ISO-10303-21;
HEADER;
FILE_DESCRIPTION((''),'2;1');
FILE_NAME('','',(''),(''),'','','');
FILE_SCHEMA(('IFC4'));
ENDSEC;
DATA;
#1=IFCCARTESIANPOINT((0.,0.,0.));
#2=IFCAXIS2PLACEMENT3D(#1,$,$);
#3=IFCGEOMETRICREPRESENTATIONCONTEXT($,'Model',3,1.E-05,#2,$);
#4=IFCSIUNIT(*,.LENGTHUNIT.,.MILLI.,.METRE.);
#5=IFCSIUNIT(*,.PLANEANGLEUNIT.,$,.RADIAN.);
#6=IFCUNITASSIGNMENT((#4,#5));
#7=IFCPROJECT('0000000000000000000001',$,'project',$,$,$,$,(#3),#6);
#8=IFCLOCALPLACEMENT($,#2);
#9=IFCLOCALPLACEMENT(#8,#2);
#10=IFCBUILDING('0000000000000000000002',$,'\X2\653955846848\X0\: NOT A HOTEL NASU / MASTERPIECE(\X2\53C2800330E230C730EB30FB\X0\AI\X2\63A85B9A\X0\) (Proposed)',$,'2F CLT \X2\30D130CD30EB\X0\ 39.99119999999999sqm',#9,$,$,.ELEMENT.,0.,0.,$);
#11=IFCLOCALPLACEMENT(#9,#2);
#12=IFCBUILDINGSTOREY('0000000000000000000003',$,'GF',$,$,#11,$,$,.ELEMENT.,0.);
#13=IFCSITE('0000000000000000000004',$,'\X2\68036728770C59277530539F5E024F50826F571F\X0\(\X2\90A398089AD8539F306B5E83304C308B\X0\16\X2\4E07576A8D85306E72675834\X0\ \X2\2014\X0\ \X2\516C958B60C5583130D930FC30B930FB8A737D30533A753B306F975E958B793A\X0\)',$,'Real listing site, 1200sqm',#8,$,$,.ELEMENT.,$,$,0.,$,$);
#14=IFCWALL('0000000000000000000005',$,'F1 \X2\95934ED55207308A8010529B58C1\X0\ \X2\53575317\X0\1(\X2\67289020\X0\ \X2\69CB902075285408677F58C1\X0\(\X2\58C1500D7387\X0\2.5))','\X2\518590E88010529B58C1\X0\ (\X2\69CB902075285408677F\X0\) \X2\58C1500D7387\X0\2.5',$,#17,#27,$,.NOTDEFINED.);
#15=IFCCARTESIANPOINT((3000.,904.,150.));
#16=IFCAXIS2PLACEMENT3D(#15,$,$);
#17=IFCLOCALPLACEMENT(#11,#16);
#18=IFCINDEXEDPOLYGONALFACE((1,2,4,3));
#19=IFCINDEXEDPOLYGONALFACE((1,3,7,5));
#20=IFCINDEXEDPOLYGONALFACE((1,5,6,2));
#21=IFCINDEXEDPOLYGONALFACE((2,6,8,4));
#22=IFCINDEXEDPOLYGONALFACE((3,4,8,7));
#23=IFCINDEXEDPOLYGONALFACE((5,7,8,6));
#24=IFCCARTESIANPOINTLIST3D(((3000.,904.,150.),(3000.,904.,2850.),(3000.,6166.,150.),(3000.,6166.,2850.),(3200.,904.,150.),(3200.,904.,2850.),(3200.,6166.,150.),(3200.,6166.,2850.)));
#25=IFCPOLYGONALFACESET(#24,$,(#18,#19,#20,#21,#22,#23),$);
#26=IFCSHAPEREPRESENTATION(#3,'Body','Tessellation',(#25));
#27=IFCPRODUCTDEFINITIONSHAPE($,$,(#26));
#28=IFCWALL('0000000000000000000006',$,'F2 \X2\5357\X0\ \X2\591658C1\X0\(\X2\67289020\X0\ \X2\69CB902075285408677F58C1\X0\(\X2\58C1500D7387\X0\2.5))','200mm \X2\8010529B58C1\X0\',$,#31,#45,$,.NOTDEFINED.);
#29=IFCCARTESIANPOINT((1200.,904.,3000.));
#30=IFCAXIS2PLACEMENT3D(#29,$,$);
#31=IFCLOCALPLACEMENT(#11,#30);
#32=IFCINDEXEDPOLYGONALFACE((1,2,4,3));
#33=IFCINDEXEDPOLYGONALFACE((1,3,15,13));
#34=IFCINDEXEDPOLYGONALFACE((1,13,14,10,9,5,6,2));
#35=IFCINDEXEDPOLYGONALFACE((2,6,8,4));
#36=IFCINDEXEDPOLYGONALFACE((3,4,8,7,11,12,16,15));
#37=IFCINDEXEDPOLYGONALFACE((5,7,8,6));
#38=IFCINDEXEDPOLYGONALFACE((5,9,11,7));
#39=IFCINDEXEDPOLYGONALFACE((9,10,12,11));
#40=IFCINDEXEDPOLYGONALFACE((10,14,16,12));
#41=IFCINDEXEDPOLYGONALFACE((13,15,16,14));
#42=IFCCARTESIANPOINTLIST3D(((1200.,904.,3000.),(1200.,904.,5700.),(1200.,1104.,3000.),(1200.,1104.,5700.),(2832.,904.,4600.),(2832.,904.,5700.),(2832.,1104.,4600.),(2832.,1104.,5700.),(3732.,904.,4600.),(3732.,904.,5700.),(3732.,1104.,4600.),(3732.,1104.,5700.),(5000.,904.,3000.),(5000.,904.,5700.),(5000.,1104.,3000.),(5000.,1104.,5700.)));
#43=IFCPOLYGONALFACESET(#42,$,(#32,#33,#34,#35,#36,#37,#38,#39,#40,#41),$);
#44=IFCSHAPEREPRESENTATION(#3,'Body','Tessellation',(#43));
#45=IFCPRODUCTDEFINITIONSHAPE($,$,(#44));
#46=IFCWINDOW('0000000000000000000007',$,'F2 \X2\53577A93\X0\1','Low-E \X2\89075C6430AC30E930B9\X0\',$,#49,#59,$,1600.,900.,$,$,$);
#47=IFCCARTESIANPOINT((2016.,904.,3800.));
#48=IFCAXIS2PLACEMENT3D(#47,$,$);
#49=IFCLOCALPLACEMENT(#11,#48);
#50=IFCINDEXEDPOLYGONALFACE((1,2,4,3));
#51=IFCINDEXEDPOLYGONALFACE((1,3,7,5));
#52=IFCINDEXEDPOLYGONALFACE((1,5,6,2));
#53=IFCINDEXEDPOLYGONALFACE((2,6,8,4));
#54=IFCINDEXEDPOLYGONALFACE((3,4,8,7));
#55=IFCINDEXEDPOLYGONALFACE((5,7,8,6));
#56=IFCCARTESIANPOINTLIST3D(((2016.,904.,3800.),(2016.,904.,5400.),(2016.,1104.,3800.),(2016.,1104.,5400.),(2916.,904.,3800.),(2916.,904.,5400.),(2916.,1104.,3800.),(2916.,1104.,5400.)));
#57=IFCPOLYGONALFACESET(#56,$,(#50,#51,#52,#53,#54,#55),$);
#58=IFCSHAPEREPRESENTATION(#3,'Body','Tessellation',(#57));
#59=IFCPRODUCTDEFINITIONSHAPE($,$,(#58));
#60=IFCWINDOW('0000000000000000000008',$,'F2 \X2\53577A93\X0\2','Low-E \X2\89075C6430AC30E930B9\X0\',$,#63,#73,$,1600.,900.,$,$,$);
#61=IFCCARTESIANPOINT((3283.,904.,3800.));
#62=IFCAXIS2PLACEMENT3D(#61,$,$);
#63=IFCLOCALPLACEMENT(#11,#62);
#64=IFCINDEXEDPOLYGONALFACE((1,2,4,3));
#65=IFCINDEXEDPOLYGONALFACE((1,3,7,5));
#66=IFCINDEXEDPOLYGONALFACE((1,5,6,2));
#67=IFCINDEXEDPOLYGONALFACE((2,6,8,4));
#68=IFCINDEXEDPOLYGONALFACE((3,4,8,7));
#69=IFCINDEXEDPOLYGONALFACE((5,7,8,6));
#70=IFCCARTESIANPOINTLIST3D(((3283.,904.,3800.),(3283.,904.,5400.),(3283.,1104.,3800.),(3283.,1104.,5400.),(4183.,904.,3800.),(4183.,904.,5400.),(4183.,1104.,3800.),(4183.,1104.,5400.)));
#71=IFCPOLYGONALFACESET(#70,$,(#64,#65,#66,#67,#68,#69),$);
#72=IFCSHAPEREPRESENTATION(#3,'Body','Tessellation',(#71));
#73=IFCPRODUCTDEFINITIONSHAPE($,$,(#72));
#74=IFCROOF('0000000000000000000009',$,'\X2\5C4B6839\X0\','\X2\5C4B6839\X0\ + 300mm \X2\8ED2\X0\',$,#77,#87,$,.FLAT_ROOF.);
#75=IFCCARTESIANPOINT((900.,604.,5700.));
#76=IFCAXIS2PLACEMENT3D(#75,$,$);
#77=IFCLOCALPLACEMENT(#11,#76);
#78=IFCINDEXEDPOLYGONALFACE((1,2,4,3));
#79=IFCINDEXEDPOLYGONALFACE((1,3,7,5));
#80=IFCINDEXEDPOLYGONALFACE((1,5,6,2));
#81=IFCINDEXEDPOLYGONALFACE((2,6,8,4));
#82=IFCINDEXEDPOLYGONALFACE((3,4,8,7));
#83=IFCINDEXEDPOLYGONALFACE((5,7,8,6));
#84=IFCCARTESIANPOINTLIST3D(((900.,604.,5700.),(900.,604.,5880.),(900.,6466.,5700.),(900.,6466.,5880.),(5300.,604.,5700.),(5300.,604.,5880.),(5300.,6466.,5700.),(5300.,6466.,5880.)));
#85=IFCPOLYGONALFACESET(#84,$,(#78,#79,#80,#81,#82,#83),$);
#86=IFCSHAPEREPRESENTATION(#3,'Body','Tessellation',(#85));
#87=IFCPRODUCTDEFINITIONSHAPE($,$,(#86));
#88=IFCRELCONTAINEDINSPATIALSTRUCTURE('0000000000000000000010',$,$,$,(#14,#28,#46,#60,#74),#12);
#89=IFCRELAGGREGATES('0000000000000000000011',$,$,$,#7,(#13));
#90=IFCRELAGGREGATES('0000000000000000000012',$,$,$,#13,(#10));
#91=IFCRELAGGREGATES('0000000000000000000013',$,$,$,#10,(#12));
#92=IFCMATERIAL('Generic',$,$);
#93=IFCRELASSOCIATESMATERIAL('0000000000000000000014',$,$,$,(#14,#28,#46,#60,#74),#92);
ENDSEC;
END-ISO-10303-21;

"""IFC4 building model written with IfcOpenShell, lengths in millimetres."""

from ifc_helpers import new_model, si_unit, frame, frame_2d, origin, place, context, project, spatial, rectangle, extrude, material, element, fill, save


model = new_model("IFC4")

# Units and contexts
model_context = context("Model", 3, precision=1e-05, world=origin())
ifc_project = project(units=[si_unit("LENGTHUNIT", "METRE", prefix="MILLI"), si_unit("PLANEANGLEUNIT", "RADIAN")], contexts=[model_context])

# Site, building, storey
site_placement = place(None, origin())
site = spatial("IfcSite", under=ifc_project, at=site_placement, Name="栃木県大田原市佐良土(那須高原に広がる16万坪超の牧場 — 公開情報ベース・詳細区画は非開示)", ObjectType="Real listing site, 1200sqm", CompositionType="ELEMENT", RefElevation=0.0)
building_placement = place(site_placement, origin())
building = spatial("IfcBuilding", under=site, at=building_placement, Name="改善案: NOT A HOTEL NASU / MASTERPIECE(参考モデル・AI推定) (Proposed)", ObjectType="2F CLT パネル 39.99119999999999sqm", CompositionType="ELEMENT", ElevationOfRefHeight=0.0, ElevationOfTerrain=0.0)
storey_placement = place(building_placement, origin())
storey = spatial("IfcBuildingStorey", under=building, at=storey_placement, Name="GF", CompositionType="ELEMENT", Elevation=0.0)

# Shared definitions
ifc_material_1 = material(Name="Generic")

# Wall
wall_1_placement = place(storey_placement, frame((3000.0, 904.0, 150.0)))
element("IfcWall", 1, at=wall_1_placement, inside=storey, material=ifc_material_1, Name="F1 間仕切り耐力壁 南北1(木造 構造用合板壁(壁倍率2.5))", Description="内部耐力壁 (構造用合板) 壁倍率2.5", PredefinedType="NOTDEFINED", context=model_context, shape_type="SweptSolid", body=[
    extrude(rectangle(XDim=200.0, YDim=5262.0, at=frame_2d((100.0, 2631.0))), frame((3000.0, 904.0, 150.0)), (0.0, 0.0, 1.0), 2700.0),
])

# Wall, openings, windows
wall_2_placement = place(storey_placement, frame((1200.0, 904.0, 3000.0)))
wall_2 = element("IfcWall", 2, at=wall_2_placement, inside=storey, material=ifc_material_1, Name="F2 南 外壁(木造 構造用合板壁(壁倍率2.5))", Description="200mm 耐力壁", PredefinedType="NOTDEFINED", context=model_context, shape_type="SweptSolid", body=[
    extrude(rectangle(XDim=3800.0, YDim=200.0, at=frame_2d((1900.0, 100.0))), frame((1200.0, 904.0, 3000.0)), (0.0, 0.0, 1.0), 2700.0),
])
opening_1_placement = place(storey_placement, frame((2016.0, 904.0, 3800.0)))
opening_1 = element("IfcOpeningElement", 3, at=opening_1_placement, cuts=wall_2, PredefinedType="NOTDEFINED", context=model_context, shape_type="SweptSolid", body=[
    extrude(rectangle(XDim=900.0, YDim=200.0, at=frame_2d((450.0, 100.0))), frame((2016.0, 904.0, 3800.0)), (0.0, 0.0, 1.0), 1600.0),
])
opening_2_placement = place(storey_placement, frame((3283.0, 904.0, 3800.0)))
opening_2 = element("IfcOpeningElement", 4, at=opening_2_placement, cuts=wall_2, PredefinedType="NOTDEFINED", context=model_context, shape_type="SweptSolid", body=[
    extrude(rectangle(XDim=900.0, YDim=200.0, at=frame_2d((450.0, 100.0))), frame((3283.0, 904.0, 3800.0)), (0.0, 0.0, 1.0), 1600.0),
])
window_1_placement = place(storey_placement, frame((2016.0, 904.0, 3800.0)))
window_1 = element("IfcWindow", 5, at=window_1_placement, inside=storey, material=ifc_material_1, Name="F2 南窓1", Description="Low-E 複層ガラス", OverallHeight=1600.0, OverallWidth=900.0, context=model_context, shape_type="SweptSolid", body=[
    extrude(rectangle(XDim=900.0, YDim=200.0, at=frame_2d((450.0, 100.0))), frame((2016.0, 904.0, 3800.0)), (0.0, 0.0, 1.0), 1600.0),
])
fill(opening_1, window_1)
window_2_placement = place(storey_placement, frame((3283.0, 904.0, 3800.0)))
window_2 = element("IfcWindow", 6, at=window_2_placement, inside=storey, material=ifc_material_1, Name="F2 南窓2", Description="Low-E 複層ガラス", OverallHeight=1600.0, OverallWidth=900.0, context=model_context, shape_type="SweptSolid", body=[
    extrude(rectangle(XDim=900.0, YDim=200.0, at=frame_2d((450.0, 100.0))), frame((3283.0, 904.0, 3800.0)), (0.0, 0.0, 1.0), 1600.0),
])
fill(opening_2, window_2)

# Roof
roof_placement = place(storey_placement, frame((900.0, 604.0, 5700.0)))
element("IfcRoof", 7, at=roof_placement, inside=storey, material=ifc_material_1, Name="屋根", Description="屋根 + 300mm 軒", PredefinedType="FLAT_ROOF", context=model_context, shape_type="SweptSolid", body=[
    extrude(rectangle(XDim=4400.0, YDim=5862.0, at=frame_2d((2200.0, 2931.0))), frame((900.0, 604.0, 5700.0)), (0.0, 0.0, 1.0), 180.0),
])

save(model, "model.ifc")
